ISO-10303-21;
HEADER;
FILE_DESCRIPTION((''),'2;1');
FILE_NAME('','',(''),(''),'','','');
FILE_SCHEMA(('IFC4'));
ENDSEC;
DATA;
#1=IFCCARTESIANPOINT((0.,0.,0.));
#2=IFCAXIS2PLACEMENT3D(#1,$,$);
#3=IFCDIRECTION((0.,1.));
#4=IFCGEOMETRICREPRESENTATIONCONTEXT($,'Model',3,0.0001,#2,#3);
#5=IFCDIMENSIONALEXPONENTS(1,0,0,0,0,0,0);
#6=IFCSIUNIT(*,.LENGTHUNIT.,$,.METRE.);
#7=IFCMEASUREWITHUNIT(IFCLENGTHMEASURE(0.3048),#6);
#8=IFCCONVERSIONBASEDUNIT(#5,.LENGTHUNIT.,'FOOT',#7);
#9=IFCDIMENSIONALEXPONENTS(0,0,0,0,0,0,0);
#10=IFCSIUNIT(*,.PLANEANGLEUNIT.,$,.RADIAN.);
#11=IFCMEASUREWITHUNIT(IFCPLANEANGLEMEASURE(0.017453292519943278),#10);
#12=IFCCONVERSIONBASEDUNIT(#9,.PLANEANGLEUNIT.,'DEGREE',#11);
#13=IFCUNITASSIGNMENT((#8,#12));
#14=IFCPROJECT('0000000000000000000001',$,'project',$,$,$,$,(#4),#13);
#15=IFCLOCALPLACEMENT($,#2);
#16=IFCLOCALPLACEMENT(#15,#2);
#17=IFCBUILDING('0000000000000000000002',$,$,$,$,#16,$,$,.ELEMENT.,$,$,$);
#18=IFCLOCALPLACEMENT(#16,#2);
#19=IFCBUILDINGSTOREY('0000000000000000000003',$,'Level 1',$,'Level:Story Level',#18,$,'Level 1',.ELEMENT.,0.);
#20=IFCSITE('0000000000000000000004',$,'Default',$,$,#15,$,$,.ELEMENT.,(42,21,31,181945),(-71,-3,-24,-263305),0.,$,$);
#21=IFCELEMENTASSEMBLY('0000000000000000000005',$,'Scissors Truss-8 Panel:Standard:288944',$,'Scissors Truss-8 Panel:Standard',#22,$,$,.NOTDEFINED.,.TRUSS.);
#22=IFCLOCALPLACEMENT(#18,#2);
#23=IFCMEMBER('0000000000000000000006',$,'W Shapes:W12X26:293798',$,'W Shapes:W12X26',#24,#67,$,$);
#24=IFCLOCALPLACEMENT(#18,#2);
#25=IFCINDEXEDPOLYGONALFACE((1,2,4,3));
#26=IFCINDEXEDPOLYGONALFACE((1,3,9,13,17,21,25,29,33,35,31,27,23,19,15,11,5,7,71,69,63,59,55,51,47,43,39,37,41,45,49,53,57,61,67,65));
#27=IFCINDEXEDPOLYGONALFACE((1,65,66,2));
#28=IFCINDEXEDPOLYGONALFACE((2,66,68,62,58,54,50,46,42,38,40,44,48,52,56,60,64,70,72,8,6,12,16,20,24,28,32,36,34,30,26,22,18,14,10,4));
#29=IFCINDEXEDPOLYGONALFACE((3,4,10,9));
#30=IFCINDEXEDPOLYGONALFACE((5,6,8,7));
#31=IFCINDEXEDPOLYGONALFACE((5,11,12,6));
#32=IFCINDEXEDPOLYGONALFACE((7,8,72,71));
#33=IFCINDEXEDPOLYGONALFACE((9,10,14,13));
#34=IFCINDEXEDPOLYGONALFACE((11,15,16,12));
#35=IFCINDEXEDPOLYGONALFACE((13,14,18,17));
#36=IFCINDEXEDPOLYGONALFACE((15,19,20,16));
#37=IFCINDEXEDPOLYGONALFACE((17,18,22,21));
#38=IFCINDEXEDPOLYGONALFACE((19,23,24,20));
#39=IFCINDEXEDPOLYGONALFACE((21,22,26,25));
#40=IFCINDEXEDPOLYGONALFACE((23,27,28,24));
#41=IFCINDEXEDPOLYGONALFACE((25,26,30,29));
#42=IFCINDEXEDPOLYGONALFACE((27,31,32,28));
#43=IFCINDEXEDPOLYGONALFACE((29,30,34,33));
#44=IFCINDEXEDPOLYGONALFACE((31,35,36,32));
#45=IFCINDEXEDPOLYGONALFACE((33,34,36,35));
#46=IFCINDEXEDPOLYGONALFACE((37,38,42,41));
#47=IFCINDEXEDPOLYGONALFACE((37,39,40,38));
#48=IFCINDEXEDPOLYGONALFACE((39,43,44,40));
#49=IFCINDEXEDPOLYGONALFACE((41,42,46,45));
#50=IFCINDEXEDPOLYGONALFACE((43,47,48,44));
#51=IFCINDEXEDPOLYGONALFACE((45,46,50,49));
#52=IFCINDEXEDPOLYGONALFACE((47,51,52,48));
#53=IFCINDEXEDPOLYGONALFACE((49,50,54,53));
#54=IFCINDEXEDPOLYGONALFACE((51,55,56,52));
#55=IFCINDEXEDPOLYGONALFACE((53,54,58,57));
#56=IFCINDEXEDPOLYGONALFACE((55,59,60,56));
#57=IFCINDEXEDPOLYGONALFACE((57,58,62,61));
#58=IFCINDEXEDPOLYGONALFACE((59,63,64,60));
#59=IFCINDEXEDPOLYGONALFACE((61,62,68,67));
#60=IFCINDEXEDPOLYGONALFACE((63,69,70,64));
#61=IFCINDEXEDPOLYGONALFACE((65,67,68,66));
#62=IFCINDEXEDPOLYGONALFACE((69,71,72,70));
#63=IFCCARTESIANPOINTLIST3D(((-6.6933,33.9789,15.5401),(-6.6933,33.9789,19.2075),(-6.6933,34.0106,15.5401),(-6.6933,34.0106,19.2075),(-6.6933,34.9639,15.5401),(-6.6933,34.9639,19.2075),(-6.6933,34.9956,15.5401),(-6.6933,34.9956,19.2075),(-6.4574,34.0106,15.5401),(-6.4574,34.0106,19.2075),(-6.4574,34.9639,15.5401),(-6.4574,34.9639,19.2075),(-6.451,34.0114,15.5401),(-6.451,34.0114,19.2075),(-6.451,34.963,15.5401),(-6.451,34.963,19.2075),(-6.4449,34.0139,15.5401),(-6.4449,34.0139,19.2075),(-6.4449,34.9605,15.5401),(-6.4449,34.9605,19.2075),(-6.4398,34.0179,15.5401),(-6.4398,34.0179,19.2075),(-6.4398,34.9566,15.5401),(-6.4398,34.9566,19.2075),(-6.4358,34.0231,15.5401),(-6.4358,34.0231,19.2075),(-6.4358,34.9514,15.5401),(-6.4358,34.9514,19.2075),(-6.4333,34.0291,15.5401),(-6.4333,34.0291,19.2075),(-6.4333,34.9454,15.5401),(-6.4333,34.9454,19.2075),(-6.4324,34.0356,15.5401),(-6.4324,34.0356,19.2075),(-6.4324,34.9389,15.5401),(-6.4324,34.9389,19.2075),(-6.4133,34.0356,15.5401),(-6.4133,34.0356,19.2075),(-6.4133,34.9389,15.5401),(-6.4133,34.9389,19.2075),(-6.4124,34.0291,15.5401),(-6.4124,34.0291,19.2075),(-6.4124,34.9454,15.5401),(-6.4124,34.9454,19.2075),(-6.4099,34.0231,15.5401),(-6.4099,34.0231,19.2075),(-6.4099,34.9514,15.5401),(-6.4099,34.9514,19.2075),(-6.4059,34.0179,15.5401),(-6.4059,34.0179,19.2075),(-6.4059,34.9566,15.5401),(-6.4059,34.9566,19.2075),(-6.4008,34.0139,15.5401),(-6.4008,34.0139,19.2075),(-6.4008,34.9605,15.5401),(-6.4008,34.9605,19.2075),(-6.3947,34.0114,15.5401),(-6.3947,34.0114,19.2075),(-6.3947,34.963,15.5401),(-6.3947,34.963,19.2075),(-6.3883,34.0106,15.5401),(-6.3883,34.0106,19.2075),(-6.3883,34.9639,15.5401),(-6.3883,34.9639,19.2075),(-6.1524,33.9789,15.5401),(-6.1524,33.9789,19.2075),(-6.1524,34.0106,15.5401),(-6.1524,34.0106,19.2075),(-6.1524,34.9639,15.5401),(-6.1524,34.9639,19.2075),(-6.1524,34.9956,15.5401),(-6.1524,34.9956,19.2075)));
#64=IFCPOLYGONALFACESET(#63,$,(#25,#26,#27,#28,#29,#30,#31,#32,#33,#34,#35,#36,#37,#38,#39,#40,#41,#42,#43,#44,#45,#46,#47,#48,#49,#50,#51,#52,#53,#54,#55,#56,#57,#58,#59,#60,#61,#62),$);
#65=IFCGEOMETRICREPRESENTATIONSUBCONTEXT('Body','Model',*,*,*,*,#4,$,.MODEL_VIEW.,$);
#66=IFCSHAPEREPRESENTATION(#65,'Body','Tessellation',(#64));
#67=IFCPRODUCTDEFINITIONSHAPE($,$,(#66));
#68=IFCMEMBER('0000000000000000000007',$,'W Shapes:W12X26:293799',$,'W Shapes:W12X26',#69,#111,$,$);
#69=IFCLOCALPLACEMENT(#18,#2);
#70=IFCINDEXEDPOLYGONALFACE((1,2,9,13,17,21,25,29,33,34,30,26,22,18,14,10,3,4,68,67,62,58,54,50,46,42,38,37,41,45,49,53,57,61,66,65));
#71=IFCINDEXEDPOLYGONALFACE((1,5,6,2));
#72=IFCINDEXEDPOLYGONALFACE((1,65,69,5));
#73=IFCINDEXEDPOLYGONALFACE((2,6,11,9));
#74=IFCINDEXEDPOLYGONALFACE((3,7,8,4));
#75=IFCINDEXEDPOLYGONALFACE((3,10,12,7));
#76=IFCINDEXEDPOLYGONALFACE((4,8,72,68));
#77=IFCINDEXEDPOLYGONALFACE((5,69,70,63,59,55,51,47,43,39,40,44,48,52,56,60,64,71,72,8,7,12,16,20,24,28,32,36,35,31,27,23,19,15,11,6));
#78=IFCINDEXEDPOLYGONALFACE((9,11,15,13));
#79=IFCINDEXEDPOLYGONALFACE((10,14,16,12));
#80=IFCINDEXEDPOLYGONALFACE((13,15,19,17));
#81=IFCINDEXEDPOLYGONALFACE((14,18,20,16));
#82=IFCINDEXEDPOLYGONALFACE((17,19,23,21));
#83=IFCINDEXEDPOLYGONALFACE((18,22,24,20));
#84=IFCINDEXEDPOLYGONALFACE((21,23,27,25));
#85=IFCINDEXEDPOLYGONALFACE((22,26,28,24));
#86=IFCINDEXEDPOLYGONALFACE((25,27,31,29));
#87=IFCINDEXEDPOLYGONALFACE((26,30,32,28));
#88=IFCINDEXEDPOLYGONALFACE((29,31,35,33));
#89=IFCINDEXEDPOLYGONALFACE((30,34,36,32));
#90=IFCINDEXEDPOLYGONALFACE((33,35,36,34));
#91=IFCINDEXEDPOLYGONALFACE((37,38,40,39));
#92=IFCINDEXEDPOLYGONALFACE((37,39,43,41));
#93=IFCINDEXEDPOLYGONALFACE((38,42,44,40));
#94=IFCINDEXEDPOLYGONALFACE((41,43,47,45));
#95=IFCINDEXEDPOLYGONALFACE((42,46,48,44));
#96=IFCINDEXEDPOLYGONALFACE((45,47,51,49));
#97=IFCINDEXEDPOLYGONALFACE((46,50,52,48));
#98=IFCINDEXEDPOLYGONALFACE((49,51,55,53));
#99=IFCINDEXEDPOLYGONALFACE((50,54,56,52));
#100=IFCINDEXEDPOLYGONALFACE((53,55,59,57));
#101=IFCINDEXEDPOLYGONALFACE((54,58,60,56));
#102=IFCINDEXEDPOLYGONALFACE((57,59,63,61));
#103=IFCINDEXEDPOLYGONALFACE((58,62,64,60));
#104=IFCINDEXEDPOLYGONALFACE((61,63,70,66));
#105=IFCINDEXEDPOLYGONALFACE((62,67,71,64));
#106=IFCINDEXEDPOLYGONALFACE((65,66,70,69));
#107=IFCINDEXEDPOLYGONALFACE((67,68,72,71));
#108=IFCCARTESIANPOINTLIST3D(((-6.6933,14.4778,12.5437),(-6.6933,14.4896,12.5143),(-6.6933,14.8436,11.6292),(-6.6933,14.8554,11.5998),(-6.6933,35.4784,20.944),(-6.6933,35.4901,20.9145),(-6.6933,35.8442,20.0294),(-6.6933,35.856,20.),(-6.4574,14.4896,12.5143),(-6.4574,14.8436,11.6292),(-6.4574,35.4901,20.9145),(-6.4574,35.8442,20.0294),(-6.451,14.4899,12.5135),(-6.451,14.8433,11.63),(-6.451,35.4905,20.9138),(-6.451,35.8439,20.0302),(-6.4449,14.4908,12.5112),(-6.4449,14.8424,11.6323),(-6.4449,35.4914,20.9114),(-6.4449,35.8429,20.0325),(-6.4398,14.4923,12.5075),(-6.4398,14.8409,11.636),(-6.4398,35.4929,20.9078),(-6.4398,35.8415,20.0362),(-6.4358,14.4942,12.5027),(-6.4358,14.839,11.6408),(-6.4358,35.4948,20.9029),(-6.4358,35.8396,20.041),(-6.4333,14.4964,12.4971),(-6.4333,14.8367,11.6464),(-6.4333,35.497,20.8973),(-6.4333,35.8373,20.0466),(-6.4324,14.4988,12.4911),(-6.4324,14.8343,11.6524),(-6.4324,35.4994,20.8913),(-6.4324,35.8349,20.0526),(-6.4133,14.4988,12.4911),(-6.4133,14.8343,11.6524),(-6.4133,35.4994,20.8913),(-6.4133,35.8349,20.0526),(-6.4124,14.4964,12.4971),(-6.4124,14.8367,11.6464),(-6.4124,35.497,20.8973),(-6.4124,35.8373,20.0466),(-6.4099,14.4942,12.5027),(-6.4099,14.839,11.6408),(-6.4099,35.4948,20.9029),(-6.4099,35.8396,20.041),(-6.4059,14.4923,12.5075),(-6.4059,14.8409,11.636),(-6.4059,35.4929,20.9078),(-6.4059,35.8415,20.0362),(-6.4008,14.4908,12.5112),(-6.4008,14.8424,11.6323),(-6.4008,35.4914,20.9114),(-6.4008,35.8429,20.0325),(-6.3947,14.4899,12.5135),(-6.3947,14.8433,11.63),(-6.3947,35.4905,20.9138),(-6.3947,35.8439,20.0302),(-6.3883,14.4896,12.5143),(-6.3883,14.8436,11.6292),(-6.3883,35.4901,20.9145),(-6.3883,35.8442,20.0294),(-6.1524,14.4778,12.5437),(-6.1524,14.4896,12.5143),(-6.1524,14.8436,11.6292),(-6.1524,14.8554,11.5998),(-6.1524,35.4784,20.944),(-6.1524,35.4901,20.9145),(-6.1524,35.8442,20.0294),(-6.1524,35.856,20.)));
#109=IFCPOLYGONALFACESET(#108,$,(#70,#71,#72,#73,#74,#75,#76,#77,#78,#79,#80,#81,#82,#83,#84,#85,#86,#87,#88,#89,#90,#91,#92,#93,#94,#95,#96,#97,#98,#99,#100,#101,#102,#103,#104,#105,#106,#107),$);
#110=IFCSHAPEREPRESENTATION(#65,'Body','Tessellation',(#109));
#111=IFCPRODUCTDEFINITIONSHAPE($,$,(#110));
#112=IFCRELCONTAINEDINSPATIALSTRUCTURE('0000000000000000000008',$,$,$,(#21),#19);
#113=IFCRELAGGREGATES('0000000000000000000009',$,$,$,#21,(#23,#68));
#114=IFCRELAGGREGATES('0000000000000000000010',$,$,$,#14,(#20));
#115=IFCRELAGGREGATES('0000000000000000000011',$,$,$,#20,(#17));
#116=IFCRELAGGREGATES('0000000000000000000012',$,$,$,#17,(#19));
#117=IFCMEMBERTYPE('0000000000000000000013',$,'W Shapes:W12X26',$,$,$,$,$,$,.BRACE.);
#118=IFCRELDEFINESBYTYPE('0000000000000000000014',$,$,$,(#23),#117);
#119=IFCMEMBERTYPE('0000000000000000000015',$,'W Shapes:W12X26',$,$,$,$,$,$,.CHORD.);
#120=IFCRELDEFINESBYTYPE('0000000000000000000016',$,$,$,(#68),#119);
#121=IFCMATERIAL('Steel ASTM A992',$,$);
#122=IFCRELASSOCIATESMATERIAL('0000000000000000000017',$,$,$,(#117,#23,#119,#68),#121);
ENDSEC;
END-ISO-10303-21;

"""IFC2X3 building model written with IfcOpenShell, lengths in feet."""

from ifc_helpers import new_model, entity, si_unit, converted_unit, direction, frame, frame_2d, origin, place, context, subcontext, project, spatial, polyline, circle_curve, parameter, trimmed, segment, composite_curve, outline, extrude, source, transform, mapped, material, type_object, type_shapes, element, aggregate, save


model = new_model("IFC2X3")

# Units and contexts
model_context = context("Model", 3, precision=0.0001, world=origin(), true_north=direction((0.0, 1.0)))
body_context = subcontext(model_context, "Body", "Model", "MODEL_VIEW")
ifc_project = project(units=[converted_unit("LENGTHUNIT", "FOOT", entity("IfcLengthMeasure", 0.3048), si_unit("LENGTHUNIT", "METRE"), dimensions=[1, 0, 0, 0, 0, 0, 0]), converted_unit("PLANEANGLEUNIT", "DEGREE", entity("IfcPlaneAngleMeasure", 0.017453292519943278), si_unit("PLANEANGLEUNIT", "RADIAN"), dimensions=[0, 0, 0, 0, 0, 0, 0])], contexts=[model_context])

# Site, building, storey
site_placement = place(None, origin())
site = spatial("IfcSite", under=ifc_project, at=site_placement, Name="Default", CompositionType="ELEMENT", RefLatitude=(42, 21, 31, 181945), RefLongitude=(-71, -3, -24, -263305), RefElevation=0.0)
building_placement = place(site_placement, origin())
building = spatial("IfcBuilding", under=site, at=building_placement, CompositionType="ELEMENT")
storey_placement = place(building_placement, origin())
storey = spatial("IfcBuildingStorey", under=building, at=storey_placement, Name="Level 1", ObjectType="Level:Story Level", LongName="Level 1", CompositionType="ELEMENT", Elevation=0.0)

# Element assembly, members
assembly_placement = place(storey_placement, origin())
assembly = element("IfcElementAssembly", 1, at=assembly_placement, inside=storey, Name="Scissors Truss-8 Panel:Standard:288944", ObjectType="Scissors Truss-8 Panel:Standard", AssemblyPlace="NOTDEFINED", PredefinedType="TRUSS")
ifc_material = material(Name="Steel ASTM A992")
member_type_1 = type_object("IfcMemberType", Name="W Shapes:W12X26", PredefinedType="BRACE", material=ifc_material)
shared_shape_1 = source(origin(), body_context, "Body", "SweptSolid", [
    extrude(outline(composite_curve([segment(polyline([(-0.2704, -0.4767), (-0.2704, -0.5083)]), True, "CONTINUOUS"), segment(polyline([(-0.2704, -0.5083), (0.2704, -0.5083)]), True, "CONTINUOUS"), segment(polyline([(0.2704, -0.5083), (0.2704, -0.4767)]), True, "CONTINUOUS"), segment(polyline([(0.2704, -0.4767), (0.0346, -0.4767)]), True, "CONTINUOUS"), segment(trimmed(circle_curve(frame_2d((0.0346, -0.4517), x_axis=(1.0, 0.0)), 0.025), [parameter(180.0)], [parameter(270.0)], True, "PARAMETER"), False, "CONTINUOUS"), segment(polyline([(0.0096, -0.4517), (0.0096, 0.4517)]), True, "CONTINUOUS"), segment(trimmed(circle_curve(frame_2d((0.0346, 0.4517), x_axis=(1.0, 0.0)), 0.025), [parameter(90.0)], [parameter(180.0)], True, "PARAMETER"), False, "CONTINUOUS"), segment(polyline([(0.0346, 0.4767), (0.2704, 0.4767)]), True, "CONTINUOUS"), segment(polyline([(0.2704, 0.4767), (0.2704, 0.5083)]), True, "CONTINUOUS"), segment(polyline([(0.2704, 0.5083), (-0.2704, 0.5083)]), True, "CONTINUOUS"), segment(polyline([(-0.2704, 0.5083), (-0.2704, 0.4767)]), True, "CONTINUOUS"), segment(polyline([(-0.2704, 0.4767), (-0.0346, 0.4767)]), True, "CONTINUOUS"), segment(trimmed(circle_curve(frame_2d((-0.0346, 0.4517), x_axis=(1.0, 0.0)), 0.025), [parameter(360.0)], [parameter(90.0)], True, "PARAMETER"), False, "CONTINUOUS"), segment(polyline([(-0.0096, 0.4517), (-0.0096, -0.4517)]), True, "CONTINUOUS"), segment(trimmed(circle_curve(frame_2d((-0.0346, -0.4517), x_axis=(1.0, 0.0)), 0.025), [parameter(270.0)], [parameter(360.0)], True, "PARAMETER"), False, "CONTINUOUS"), segment(polyline([(-0.0346, -0.4767), (-0.2704, -0.4767)]), True, "CONTINUOUS")], self_intersect=False)), frame((-1.9599, 0.0, 0.0), z_axis=(-1.0, 0.0, 0.0), x_axis=(0.0, -1.0, 0.0)), (0.0, 0.0, -1.0), 3.6674),
])
type_shapes(member_type_1, [shared_shape_1])
member_1_placement = place(assembly_placement, frame((-6.4228, 34.4872, 17.5), z_axis=(0.0, 1.0, 0.0), x_axis=(0.0, 0.0, 1.0)))
member_1 = element("IfcMember", 2, at=member_1_placement, type_object=member_type_1, material=ifc_material, Name="W Shapes:W12X26:293798", ObjectType="W Shapes:W12X26", context=body_context, shape_type="MappedRepresentation", body=[
    mapped(shared_shape_1, transform((0.0, 0.0, 0.0), scale=1.0)),
])
member_type_2 = type_object("IfcMemberType", Name="W Shapes:W12X26", PredefinedType="CHORD", material=ifc_material)
shared_shape_2 = source(origin(), body_context, "Body", "SweptSolid", [
    extrude(outline(composite_curve([segment(polyline([(-0.2704, -0.4767), (-0.2704, -0.5083)]), True, "CONTINUOUS"), segment(polyline([(-0.2704, -0.5083), (0.2704, -0.5083)]), True, "CONTINUOUS"), segment(polyline([(0.2704, -0.5083), (0.2704, -0.4767)]), True, "CONTINUOUS"), segment(polyline([(0.2704, -0.4767), (0.0346, -0.4767)]), True, "CONTINUOUS"), segment(trimmed(circle_curve(frame_2d((0.0346, -0.4517), x_axis=(1.0, 0.0)), 0.025), [parameter(180.0)], [parameter(270.0)], True, "PARAMETER"), False, "CONTINUOUS"), segment(polyline([(0.0096, -0.4517), (0.0096, 0.4517)]), True, "CONTINUOUS"), segment(trimmed(circle_curve(frame_2d((0.0346, 0.4517), x_axis=(1.0, 0.0)), 0.025), [parameter(90.0)], [parameter(180.0)], True, "PARAMETER"), False, "CONTINUOUS"), segment(polyline([(0.0346, 0.4767), (0.2704, 0.4767)]), True, "CONTINUOUS"), segment(polyline([(0.2704, 0.4767), (0.2704, 0.5083)]), True, "CONTINUOUS"), segment(polyline([(0.2704, 0.5083), (-0.2704, 0.5083)]), True, "CONTINUOUS"), segment(polyline([(-0.2704, 0.5083), (-0.2704, 0.4767)]), True, "CONTINUOUS"), segment(polyline([(-0.2704, 0.4767), (-0.0346, 0.4767)]), True, "CONTINUOUS"), segment(trimmed(circle_curve(frame_2d((-0.0346, 0.4517), x_axis=(1.0, 0.0)), 0.025), [parameter(360.0)], [parameter(90.0)], True, "PARAMETER"), False, "CONTINUOUS"), segment(polyline([(-0.0096, 0.4517), (-0.0096, -0.4517)]), True, "CONTINUOUS"), segment(trimmed(circle_curve(frame_2d((-0.0346, -0.4517), x_axis=(1.0, 0.0)), 0.025), [parameter(270.0)], [parameter(360.0)], True, "PARAMETER"), False, "CONTINUOUS"), segment(polyline([(-0.0346, -0.4767), (-0.2704, -0.4767)]), True, "CONTINUOUS")], self_intersect=False)), frame((-7.8846, 0.0, 0.0), z_axis=(-1.0, 0.0, 0.0), x_axis=(0.0, -1.0, 0.0)), (0.0, 0.0, -1.0), 22.6183),
])
type_shapes(member_type_2, [shared_shape_2])
member_2_placement = place(assembly_placement, frame((-6.4228, 21.9872, 15.0), z_axis=(0.0, -0.371391, 0.928477), x_axis=(0.0, 0.928477, 0.371391)))
member_2 = element("IfcMember", 3, at=member_2_placement, type_object=member_type_2, material=ifc_material, Name="W Shapes:W12X26:293799", ObjectType="W Shapes:W12X26", context=body_context, shape_type="MappedRepresentation", body=[
    mapped(shared_shape_2, transform((0.0, 0.0, 0.0), scale=1.0)),
])
aggregate(assembly, [member_1, member_2])

save(model, "model.ifc")
